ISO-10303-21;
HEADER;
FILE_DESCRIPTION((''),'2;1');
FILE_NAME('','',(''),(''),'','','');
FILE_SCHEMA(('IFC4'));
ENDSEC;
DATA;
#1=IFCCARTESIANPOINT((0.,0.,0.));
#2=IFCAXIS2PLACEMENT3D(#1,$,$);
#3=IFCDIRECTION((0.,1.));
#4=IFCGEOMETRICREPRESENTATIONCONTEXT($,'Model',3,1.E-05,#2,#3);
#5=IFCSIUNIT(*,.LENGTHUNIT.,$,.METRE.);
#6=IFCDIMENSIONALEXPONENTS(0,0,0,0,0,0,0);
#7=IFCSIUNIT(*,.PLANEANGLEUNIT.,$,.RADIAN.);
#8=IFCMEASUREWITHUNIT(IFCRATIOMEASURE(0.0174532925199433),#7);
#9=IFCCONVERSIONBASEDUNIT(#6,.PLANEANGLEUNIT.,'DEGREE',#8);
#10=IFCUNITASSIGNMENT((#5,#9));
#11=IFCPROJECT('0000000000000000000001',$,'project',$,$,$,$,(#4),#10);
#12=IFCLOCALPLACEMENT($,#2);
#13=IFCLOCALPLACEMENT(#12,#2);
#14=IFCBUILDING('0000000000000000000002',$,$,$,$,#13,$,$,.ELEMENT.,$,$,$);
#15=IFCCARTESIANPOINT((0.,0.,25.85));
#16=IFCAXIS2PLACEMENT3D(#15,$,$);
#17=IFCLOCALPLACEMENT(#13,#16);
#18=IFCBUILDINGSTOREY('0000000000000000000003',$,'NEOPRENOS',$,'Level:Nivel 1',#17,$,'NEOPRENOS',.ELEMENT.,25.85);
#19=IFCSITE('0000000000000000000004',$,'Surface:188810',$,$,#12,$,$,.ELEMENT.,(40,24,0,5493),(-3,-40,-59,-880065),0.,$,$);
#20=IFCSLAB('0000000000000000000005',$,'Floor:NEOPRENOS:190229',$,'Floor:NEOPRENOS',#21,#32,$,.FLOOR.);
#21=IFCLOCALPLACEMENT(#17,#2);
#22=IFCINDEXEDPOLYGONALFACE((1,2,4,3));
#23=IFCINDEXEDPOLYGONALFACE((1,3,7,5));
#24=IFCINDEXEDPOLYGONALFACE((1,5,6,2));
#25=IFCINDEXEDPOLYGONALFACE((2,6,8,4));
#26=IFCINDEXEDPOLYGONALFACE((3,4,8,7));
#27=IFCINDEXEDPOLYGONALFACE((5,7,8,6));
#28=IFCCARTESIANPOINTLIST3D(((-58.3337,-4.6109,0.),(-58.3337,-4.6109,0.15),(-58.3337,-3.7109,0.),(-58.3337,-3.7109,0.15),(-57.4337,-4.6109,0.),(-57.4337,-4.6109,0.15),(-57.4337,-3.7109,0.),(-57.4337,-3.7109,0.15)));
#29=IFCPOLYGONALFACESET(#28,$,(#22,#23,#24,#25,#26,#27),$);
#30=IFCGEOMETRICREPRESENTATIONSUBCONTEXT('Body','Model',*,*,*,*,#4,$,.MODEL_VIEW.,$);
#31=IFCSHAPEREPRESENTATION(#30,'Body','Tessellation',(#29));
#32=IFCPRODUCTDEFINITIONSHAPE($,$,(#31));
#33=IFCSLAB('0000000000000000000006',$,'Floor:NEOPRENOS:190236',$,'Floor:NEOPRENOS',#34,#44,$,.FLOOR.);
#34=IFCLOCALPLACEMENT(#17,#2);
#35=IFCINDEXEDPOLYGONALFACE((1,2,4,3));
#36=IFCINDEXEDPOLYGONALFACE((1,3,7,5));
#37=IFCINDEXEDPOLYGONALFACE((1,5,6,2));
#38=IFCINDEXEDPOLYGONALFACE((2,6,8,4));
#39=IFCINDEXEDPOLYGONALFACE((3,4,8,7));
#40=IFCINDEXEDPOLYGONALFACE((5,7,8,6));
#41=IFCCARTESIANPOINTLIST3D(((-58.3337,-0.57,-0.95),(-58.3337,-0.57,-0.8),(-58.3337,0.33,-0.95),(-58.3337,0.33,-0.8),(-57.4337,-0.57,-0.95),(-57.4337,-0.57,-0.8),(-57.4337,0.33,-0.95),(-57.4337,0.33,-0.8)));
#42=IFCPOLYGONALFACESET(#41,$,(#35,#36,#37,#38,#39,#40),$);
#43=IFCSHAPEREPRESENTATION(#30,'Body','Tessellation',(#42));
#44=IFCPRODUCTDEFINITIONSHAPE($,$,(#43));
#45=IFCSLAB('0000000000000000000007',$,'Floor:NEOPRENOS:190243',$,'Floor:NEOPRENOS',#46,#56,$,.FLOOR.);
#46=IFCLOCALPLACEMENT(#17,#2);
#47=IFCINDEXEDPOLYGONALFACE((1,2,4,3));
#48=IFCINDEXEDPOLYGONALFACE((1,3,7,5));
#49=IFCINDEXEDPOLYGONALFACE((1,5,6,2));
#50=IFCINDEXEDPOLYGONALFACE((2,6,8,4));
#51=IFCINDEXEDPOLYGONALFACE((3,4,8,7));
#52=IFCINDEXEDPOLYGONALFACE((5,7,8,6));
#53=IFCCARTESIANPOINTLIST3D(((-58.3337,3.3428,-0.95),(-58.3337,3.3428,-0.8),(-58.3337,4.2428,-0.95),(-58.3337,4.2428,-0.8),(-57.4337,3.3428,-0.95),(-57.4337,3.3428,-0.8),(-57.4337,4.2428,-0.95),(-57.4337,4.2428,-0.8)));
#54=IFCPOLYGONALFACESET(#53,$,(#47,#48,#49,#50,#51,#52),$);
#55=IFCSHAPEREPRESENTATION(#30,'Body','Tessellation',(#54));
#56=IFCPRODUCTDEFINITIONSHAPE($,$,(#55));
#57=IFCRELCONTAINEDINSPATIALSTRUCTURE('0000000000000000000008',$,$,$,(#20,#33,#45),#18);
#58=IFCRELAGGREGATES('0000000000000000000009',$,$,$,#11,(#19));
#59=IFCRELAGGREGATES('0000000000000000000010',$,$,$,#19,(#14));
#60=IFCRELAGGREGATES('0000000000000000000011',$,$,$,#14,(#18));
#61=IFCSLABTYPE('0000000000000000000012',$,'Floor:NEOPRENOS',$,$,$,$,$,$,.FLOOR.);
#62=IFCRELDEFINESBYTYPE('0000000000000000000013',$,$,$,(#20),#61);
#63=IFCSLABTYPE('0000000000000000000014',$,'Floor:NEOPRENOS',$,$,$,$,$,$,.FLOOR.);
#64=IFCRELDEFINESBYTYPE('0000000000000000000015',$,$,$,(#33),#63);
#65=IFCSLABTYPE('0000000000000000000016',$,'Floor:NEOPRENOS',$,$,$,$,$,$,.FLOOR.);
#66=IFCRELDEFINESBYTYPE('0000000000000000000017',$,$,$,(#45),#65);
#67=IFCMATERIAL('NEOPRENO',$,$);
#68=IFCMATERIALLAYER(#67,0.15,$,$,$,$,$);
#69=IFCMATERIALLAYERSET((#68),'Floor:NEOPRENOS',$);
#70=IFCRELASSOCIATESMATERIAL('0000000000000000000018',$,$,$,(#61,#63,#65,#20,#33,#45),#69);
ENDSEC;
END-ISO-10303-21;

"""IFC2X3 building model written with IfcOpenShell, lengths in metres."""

from ifc_helpers import new_model, entity, si_unit, converted_unit, direction, frame, frame_2d, origin, origin_2d_with_axis, place, context, subcontext, project, spatial, rectangle, extrude, material, layer, layer_set, layer_usage, type_object, element, save


model = new_model("IFC2X3")

# Units and contexts
model_context = context("Model", 3, precision=1e-05, world=origin(), true_north=direction((0.0, 1.0)))
body_context = subcontext(model_context, "Body", "Model", "MODEL_VIEW")
ifc_project = project(units=[si_unit("LENGTHUNIT", "METRE"), converted_unit("PLANEANGLEUNIT", "DEGREE", entity("IfcRatioMeasure", 0.0174532925199433), si_unit("PLANEANGLEUNIT", "RADIAN"), dimensions=[0, 0, 0, 0, 0, 0, 0])], contexts=[model_context])

# Site, building, storey
site_placement = place(None, origin())
site = spatial("IfcSite", under=ifc_project, at=site_placement, Name="Surface:188810", CompositionType="ELEMENT", RefLatitude=(40, 24, 0, 5493), RefLongitude=(-3, -40, -59, -880065), RefElevation=0.0)
building_placement = place(site_placement, origin())
building = spatial("IfcBuilding", under=site, at=building_placement, CompositionType="ELEMENT")
storey_placement = place(building_placement, frame((0.0, 0.0, 25.85)))
storey = spatial("IfcBuildingStorey", under=building, at=storey_placement, Name="NEOPRENOS", ObjectType="Level:Nivel 1", LongName="NEOPRENOS", CompositionType="ELEMENT", Elevation=25.85)

# Slabs
ifc_material_1 = material(Name="NEOPRENO")
ifc_layer = layer(ifc_material_1, 0.15)
ifc_layer_set = layer_set([ifc_layer], Name="Floor:NEOPRENOS")
ifc_layer_usage_1 = layer_usage(ifc_layer_set, "AXIS3", "POSITIVE", 0.0)
slab_type_1 = type_object("IfcSlabType", Name="Floor:NEOPRENOS", PredefinedType="FLOOR", material=ifc_layer_set)
slab_1_placement = place(storey_placement, origin())
element("IfcSlab", 1, at=slab_1_placement, inside=storey, type_object=slab_type_1, material=ifc_layer_usage_1, Name="Floor:NEOPRENOS:190229", ObjectType="Floor:NEOPRENOS", PredefinedType="FLOOR", context=body_context, shape_type="SweptSolid", body=[
    extrude(rectangle(XDim=0.9, YDim=0.9, at=origin_2d_with_axis()), frame((-57.8837, -4.1609, 0.15), z_axis=(0.0, 0.0, -1.0), x_axis=(0.0, 1.0, 0.0)), (0.0, 0.0, 1.0), 0.15),
])
ifc_layer_usage_2 = layer_usage(ifc_layer_set, "AXIS3", "POSITIVE", 0.0)
slab_type_2 = type_object("IfcSlabType", Name="Floor:NEOPRENOS", PredefinedType="FLOOR", material=ifc_layer_set)
slab_2_placement = place(storey_placement, origin())
element("IfcSlab", 2, at=slab_2_placement, inside=storey, type_object=slab_type_2, material=ifc_layer_usage_2, Name="Floor:NEOPRENOS:190236", ObjectType="Floor:NEOPRENOS", PredefinedType="FLOOR", context=body_context, shape_type="SweptSolid", body=[
    extrude(rectangle(XDim=0.9, YDim=0.9, at=frame_2d((0.0, 0.0), x_axis=(1.0, 0.0))), frame((-57.8837, -0.12, -0.8), z_axis=(0.0, 0.0, -1.0), x_axis=(0.0, 1.0, 0.0)), (0.0, 0.0, 1.0), 0.15),
])
ifc_layer_usage_3 = layer_usage(ifc_layer_set, "AXIS3", "POSITIVE", 0.0)
slab_type_3 = type_object("IfcSlabType", Name="Floor:NEOPRENOS", PredefinedType="FLOOR", material=ifc_layer_set)
slab_3_placement = place(storey_placement, origin())
element("IfcSlab", 3, at=slab_3_placement, inside=storey, type_object=slab_type_3, material=ifc_layer_usage_3, Name="Floor:NEOPRENOS:190243", ObjectType="Floor:NEOPRENOS", PredefinedType="FLOOR", context=body_context, shape_type="SweptSolid", body=[
    extrude(rectangle(XDim=0.9, YDim=0.9, at=origin_2d_with_axis()), frame((-57.8837, 3.7928, -0.8), z_axis=(0.0, 0.0, -1.0), x_axis=(0.0, 1.0, 0.0)), (0.0, 0.0, 1.0), 0.15),
])

save(model, "model.ifc")
